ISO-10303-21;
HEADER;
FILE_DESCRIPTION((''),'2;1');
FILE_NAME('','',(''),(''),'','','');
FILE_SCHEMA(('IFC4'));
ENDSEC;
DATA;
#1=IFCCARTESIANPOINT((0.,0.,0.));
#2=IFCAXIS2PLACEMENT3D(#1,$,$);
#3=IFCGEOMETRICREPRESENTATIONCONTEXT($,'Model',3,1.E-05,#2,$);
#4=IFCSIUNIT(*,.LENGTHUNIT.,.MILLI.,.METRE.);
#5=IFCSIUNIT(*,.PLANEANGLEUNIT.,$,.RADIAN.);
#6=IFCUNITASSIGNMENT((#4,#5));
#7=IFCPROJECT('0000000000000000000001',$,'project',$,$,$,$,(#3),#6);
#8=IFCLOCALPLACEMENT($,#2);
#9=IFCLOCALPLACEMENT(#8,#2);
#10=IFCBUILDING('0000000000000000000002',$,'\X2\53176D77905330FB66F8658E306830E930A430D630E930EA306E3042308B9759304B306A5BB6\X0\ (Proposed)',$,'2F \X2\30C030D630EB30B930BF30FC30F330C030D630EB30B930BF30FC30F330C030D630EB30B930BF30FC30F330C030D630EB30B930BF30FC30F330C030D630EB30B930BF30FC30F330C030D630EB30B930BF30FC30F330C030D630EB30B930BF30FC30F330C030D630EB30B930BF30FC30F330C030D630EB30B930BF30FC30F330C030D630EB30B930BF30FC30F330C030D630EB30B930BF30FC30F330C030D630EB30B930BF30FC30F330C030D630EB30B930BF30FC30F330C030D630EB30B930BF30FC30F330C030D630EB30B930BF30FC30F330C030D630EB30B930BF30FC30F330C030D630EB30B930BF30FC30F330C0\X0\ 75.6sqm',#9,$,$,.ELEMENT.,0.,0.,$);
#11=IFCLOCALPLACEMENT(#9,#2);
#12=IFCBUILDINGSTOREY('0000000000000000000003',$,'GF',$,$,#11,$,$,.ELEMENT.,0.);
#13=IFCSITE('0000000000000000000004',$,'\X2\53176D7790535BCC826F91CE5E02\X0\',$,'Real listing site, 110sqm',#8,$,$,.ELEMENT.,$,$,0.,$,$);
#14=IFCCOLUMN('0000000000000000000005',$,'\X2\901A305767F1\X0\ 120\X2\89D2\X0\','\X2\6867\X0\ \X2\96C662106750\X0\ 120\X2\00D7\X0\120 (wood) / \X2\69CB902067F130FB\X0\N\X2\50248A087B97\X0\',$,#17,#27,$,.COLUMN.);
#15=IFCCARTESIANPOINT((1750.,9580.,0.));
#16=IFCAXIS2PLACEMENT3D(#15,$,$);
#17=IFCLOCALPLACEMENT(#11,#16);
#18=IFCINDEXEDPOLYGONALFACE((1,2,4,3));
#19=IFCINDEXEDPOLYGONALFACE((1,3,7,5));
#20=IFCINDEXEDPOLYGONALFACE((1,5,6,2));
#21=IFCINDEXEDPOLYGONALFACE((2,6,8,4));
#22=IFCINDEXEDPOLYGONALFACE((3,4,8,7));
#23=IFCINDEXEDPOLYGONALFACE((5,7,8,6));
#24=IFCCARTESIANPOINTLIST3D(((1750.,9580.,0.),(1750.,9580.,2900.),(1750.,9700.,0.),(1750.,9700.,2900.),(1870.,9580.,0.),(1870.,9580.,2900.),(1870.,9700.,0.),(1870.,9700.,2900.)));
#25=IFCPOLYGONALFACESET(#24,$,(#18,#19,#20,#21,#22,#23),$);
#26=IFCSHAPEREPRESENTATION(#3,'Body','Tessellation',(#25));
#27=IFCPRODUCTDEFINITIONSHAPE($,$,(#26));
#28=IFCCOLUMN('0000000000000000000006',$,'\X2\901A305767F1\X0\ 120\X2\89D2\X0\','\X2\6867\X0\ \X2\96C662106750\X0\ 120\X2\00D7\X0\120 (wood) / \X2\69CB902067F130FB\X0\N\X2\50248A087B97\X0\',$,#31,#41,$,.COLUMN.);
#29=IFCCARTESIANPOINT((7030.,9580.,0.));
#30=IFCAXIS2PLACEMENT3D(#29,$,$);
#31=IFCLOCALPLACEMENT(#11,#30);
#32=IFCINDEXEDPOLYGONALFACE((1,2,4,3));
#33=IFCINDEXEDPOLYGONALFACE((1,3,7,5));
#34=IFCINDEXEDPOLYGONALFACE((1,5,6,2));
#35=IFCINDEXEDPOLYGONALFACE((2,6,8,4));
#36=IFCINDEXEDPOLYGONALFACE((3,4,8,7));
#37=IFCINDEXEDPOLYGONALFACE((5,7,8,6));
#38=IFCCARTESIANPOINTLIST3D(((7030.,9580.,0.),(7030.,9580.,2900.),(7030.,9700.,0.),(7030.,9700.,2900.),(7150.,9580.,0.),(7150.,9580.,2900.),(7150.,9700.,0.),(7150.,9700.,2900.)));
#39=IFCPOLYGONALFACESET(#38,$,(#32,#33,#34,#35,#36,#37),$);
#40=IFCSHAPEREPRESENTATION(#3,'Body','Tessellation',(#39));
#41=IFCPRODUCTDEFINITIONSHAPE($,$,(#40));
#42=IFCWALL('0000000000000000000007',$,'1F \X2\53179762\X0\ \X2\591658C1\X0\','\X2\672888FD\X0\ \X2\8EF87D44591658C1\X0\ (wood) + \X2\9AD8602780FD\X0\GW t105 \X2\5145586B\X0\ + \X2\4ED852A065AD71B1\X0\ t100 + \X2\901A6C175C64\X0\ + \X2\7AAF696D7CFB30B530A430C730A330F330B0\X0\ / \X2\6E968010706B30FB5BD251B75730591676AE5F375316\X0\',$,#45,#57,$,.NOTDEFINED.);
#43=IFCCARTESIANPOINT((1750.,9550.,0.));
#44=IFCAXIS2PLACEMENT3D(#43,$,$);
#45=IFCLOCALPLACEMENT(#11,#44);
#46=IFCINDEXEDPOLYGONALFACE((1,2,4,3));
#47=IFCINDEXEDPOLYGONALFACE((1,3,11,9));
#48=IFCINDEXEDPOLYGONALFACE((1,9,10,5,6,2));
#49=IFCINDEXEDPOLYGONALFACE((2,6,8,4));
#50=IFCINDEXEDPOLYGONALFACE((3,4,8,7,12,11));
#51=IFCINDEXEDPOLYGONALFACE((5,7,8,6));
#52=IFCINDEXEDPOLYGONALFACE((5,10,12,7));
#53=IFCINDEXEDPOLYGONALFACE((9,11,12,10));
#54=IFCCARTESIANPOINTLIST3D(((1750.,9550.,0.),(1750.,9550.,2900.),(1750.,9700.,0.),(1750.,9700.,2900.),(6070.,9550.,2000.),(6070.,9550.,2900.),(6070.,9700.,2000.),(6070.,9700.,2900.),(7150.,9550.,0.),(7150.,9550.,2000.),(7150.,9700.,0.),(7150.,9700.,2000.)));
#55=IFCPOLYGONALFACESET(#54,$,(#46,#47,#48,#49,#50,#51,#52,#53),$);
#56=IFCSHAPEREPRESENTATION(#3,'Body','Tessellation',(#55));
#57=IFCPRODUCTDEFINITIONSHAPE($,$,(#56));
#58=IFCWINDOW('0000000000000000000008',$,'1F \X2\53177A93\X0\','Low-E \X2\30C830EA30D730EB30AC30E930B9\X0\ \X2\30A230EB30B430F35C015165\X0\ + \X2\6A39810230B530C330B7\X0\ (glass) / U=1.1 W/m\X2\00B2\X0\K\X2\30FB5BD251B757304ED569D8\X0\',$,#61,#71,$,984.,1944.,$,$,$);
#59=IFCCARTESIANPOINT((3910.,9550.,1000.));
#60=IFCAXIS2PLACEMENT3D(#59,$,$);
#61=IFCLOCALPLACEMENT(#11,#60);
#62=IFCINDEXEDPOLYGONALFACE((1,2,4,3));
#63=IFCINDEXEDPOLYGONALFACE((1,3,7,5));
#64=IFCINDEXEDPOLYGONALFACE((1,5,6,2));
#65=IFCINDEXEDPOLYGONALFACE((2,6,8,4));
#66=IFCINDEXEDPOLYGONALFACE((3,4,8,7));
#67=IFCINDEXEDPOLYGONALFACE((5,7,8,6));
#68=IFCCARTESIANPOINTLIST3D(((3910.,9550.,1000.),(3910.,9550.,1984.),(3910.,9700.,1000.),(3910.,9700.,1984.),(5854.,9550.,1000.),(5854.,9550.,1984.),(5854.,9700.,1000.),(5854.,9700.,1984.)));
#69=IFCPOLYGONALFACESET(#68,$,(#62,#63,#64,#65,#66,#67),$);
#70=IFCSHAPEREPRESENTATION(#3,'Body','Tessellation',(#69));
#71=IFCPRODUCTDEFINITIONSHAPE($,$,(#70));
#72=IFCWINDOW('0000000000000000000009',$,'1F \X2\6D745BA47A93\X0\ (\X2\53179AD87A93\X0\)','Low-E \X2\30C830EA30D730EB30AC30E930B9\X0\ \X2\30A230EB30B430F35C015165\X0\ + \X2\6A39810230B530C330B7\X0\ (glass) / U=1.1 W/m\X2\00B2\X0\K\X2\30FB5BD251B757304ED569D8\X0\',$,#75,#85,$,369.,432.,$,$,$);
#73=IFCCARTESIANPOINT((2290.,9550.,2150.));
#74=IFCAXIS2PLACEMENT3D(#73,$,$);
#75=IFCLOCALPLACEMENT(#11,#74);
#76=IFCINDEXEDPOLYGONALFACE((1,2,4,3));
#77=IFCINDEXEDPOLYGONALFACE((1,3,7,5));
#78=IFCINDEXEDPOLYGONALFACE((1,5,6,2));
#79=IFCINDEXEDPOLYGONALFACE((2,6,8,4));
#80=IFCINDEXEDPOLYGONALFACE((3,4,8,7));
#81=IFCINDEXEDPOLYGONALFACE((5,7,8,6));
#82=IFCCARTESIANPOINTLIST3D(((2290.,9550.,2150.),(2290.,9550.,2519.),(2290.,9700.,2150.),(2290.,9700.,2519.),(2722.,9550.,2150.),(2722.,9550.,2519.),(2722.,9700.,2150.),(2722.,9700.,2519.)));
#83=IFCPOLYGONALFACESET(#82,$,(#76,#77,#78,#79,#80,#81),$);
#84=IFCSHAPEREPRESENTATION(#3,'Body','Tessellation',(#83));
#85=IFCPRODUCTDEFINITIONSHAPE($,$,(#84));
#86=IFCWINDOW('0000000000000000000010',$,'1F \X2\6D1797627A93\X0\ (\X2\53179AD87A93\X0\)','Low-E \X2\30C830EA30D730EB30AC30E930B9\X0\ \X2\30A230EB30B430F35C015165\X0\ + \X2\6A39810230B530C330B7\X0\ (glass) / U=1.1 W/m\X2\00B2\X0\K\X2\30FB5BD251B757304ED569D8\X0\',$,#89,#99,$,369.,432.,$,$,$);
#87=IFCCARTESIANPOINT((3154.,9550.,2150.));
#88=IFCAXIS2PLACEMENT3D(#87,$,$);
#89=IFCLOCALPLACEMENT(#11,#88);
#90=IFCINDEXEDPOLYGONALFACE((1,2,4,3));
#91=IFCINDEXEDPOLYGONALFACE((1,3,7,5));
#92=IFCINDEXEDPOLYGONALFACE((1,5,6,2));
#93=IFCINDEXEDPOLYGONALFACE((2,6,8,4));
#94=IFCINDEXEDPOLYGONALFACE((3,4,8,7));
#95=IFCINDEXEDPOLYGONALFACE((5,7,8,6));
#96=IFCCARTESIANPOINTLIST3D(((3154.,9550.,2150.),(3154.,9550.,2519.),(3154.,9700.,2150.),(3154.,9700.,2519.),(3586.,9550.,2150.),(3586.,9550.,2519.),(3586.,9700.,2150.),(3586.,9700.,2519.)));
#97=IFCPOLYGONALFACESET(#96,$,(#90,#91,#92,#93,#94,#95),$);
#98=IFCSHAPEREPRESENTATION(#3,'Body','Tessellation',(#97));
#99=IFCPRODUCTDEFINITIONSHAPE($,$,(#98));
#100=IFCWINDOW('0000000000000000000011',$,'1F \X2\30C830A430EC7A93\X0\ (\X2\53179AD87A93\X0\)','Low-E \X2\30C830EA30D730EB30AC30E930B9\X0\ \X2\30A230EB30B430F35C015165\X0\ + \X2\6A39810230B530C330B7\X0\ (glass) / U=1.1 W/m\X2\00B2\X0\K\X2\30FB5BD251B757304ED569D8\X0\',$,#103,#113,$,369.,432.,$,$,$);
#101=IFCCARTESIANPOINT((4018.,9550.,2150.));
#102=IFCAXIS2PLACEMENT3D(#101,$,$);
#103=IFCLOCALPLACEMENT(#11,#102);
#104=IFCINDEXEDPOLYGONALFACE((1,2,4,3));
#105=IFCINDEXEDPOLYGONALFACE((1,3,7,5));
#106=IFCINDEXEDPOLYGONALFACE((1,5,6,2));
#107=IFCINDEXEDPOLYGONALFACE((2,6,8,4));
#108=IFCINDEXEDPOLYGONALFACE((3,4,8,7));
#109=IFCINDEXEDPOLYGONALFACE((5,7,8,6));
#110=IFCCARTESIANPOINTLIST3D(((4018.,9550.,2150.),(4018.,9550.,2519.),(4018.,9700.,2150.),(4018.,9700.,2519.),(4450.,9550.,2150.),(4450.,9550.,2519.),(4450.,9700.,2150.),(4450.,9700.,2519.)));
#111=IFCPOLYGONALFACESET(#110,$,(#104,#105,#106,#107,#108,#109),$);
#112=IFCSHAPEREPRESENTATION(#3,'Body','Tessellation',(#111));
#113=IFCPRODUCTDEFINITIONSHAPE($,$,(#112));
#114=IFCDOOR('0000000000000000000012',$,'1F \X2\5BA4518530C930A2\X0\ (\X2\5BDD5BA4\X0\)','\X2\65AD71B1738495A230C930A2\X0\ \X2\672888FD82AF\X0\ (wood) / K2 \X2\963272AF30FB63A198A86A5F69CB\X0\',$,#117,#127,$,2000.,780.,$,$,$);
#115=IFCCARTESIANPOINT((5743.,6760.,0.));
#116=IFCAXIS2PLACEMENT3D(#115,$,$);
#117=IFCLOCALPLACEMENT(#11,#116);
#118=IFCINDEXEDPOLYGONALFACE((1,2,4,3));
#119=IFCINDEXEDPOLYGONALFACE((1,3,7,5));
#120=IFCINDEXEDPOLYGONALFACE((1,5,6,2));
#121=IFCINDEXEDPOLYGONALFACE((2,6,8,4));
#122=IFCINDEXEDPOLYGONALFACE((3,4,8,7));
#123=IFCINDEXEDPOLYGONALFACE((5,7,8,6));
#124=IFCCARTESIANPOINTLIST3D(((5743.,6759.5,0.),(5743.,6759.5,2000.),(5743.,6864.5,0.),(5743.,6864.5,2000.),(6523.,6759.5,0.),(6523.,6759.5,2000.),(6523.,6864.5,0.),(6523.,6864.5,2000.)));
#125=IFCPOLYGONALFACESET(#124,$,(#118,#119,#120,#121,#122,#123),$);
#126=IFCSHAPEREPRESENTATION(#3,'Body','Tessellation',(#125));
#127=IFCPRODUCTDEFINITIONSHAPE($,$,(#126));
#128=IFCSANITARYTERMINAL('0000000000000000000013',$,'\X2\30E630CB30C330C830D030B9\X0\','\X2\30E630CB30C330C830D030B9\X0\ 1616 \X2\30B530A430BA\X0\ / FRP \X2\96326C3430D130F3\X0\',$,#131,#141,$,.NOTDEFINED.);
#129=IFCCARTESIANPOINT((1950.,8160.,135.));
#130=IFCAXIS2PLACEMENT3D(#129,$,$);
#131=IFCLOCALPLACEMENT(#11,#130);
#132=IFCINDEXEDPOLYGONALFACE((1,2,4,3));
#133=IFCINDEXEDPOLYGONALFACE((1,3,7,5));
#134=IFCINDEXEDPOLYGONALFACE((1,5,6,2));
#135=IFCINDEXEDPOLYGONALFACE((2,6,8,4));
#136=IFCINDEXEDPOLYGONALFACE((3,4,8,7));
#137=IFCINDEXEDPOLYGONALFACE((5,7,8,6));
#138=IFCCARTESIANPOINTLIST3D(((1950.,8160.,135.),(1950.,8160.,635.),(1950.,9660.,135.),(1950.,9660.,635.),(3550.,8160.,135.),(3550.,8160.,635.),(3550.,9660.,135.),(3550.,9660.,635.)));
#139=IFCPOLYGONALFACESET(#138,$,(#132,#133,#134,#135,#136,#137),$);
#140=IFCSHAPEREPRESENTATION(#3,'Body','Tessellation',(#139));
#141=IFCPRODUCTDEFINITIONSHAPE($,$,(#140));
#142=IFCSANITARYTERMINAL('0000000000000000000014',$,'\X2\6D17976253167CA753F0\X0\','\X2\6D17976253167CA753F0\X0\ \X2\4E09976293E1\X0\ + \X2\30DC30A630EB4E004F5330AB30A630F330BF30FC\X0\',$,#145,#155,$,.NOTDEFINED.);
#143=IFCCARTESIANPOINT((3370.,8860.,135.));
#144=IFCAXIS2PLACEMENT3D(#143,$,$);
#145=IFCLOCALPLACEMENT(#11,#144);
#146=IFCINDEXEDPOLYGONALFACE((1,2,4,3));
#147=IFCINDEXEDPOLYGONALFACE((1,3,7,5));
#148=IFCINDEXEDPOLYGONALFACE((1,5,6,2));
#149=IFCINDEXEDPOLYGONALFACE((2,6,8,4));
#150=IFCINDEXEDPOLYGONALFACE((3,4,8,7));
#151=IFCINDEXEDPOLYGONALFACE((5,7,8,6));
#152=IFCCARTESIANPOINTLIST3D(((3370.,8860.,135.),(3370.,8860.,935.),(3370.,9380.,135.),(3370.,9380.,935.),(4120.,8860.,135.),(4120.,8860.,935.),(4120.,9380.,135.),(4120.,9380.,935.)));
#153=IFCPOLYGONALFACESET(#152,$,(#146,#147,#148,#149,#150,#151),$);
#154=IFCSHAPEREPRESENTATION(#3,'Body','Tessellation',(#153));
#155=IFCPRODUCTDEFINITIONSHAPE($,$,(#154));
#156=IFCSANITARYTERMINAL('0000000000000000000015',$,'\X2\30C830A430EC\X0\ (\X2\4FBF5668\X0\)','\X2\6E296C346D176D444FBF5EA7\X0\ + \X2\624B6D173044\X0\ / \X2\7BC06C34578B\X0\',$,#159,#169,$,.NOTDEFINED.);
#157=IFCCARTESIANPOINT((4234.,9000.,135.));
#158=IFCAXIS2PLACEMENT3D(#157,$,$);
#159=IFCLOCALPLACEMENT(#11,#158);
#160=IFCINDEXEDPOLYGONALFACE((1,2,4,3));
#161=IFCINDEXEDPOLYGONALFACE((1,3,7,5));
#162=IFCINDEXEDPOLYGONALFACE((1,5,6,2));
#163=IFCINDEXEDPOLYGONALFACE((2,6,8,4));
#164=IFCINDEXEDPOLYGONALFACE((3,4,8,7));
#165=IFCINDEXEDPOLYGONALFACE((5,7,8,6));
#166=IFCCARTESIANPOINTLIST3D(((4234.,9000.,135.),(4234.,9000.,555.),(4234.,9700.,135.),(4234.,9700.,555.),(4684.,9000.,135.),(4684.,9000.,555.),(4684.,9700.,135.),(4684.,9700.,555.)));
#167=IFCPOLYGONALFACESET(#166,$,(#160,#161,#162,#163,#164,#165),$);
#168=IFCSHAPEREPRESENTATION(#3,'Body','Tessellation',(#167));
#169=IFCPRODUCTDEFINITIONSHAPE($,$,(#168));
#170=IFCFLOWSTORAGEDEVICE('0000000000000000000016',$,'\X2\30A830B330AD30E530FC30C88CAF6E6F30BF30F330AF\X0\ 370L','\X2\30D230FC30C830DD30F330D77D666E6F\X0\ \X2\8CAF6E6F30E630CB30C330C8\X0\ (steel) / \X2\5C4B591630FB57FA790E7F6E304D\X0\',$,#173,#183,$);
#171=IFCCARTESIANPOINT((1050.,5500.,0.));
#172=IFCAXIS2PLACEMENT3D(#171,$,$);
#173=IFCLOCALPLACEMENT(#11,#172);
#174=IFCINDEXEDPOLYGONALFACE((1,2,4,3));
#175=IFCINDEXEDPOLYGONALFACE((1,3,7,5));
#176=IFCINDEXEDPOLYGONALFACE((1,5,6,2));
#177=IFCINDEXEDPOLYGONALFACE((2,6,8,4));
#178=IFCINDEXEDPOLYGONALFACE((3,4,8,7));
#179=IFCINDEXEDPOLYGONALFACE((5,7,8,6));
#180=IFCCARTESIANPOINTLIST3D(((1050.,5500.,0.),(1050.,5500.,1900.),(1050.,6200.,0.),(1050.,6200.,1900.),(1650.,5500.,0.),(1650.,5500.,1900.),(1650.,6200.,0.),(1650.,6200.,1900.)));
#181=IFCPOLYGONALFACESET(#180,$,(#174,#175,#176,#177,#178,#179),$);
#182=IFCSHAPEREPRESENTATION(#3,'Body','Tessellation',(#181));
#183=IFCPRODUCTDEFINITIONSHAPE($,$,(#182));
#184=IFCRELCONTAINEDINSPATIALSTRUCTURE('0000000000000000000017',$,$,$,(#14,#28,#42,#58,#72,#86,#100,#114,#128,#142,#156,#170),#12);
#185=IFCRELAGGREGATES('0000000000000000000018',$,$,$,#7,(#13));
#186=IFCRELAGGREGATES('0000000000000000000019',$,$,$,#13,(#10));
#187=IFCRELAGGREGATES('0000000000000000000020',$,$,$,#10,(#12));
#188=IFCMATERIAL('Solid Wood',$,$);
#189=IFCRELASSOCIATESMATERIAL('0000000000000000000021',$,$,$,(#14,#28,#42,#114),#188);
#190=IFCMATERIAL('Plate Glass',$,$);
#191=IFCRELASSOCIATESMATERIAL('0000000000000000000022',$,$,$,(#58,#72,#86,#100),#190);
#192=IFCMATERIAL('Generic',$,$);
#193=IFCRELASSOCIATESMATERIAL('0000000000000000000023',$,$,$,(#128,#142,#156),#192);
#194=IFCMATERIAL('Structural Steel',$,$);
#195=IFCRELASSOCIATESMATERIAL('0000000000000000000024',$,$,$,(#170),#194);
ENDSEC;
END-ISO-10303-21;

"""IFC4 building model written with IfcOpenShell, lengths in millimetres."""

from ifc_helpers import new_model, si_unit, frame, frame_2d, origin, place, context, project, spatial, rectangle, extrude, material, element, fill, save


model = new_model("IFC4")

# Units and contexts
model_context = context("Model", 3, precision=1e-05, world=origin())
ifc_project = project(units=[si_unit("LENGTHUNIT", "METRE", prefix="MILLI"), si_unit("PLANEANGLEUNIT", "RADIAN")], contexts=[model_context])

# Site, building, storey
site_placement = place(None, origin())
site = spatial("IfcSite", under=ifc_project, at=site_placement, Name="北海道富良野市", ObjectType="Real listing site, 110sqm", CompositionType="ELEMENT", RefElevation=0.0)
building_placement = place(site_placement, origin())
building = spatial("IfcBuilding", under=site, at=building_placement, Name="北海道・書斎とライブラリのある静かな家 (Proposed)", ObjectType="2F ダブルスターンダブルスターンダブルスターンダブルスターンダブルスターンダブルスターンダブルスターンダブルスターンダブルスターンダブルスターンダブルスターンダブルスターンダブルスターンダブルスターンダブルスターンダブルスターンダブルスターンダ 75.6sqm", CompositionType="ELEMENT", ElevationOfRefHeight=0.0, ElevationOfTerrain=0.0)
storey_placement = place(building_placement, origin())
storey = spatial("IfcBuildingStorey", under=building, at=storey_placement, Name="GF", CompositionType="ELEMENT", Elevation=0.0)

# Columns
ifc_material_1 = material(Name="Solid Wood")
column_1_placement = place(storey_placement, frame((1750.0, 9580.0, 0.0)))
element("IfcColumn", 1, at=column_1_placement, inside=storey, material=ifc_material_1, Name="通し柱 120角", Description="桧 集成材 120×120 (wood) / 構造柱・N値計算", PredefinedType="COLUMN", context=model_context, shape_type="SweptSolid", body=[
    extrude(rectangle(XDim=120.0, YDim=120.0, at=frame_2d((60.0, 60.0))), frame((1750.0, 9580.0, 0.0)), (0.0, 0.0, 1.0), 2900.0),
])
column_2_placement = place(storey_placement, frame((7030.0, 9580.0, 0.0)))
element("IfcColumn", 2, at=column_2_placement, inside=storey, material=ifc_material_1, Name="通し柱 120角", Description="桧 集成材 120×120 (wood) / 構造柱・N値計算", PredefinedType="COLUMN", context=model_context, shape_type="SweptSolid", body=[
    extrude(rectangle(XDim=120.0, YDim=120.0, at=frame_2d((60.0, 60.0))), frame((7030.0, 9580.0, 0.0)), (0.0, 0.0, 1.0), 2900.0),
])

# Wall, openings, windows
wall_1_placement = place(storey_placement, frame((1750.0, 9550.0, 0.0)))
wall_1 = element("IfcWall", 3, at=wall_1_placement, inside=storey, material=ifc_material_1, Name="1F 北面 外壁", Description="木製 軸組外壁 (wood) + 高性能GW t105 充填 + 付加断熱 t100 + 通気層 + 窯業系サイディング / 準耐火・寒冷地外皮強化", PredefinedType="NOTDEFINED", context=model_context, shape_type="SweptSolid", body=[
    extrude(rectangle(XDim=5400.0, YDim=150.0, at=frame_2d((2700.0, 75.0))), frame((1750.0, 9550.0, 0.0)), (0.0, 0.0, 1.0), 2900.0),
])
opening_1_placement = place(storey_placement, frame((3910.0, 9550.0, 1000.0)))
opening_1 = element("IfcOpeningElement", 4, at=opening_1_placement, cuts=wall_1, PredefinedType="NOTDEFINED", context=model_context, shape_type="SweptSolid", body=[
    extrude(rectangle(XDim=1944.0, YDim=150.0, at=frame_2d((972.0, 75.0))), frame((3910.0, 9550.0, 1000.0)), (0.0, 0.0, 1.0), 984.0),
])
opening_2_placement = place(storey_placement, frame((2290.0, 9550.0, 2150.0)))
opening_2 = element("IfcOpeningElement", 5, at=opening_2_placement, cuts=wall_1, PredefinedType="NOTDEFINED", context=model_context, shape_type="SweptSolid", body=[
    extrude(rectangle(XDim=432.0, YDim=150.0, at=frame_2d((216.0, 75.0))), frame((2290.0, 9550.0, 2150.0)), (0.0, 0.0, 1.0), 369.0),
])
opening_3_placement = place(storey_placement, frame((3154.0, 9550.0, 2150.0)))
opening_3 = element("IfcOpeningElement", 6, at=opening_3_placement, cuts=wall_1, PredefinedType="NOTDEFINED", context=model_context, shape_type="SweptSolid", body=[
    extrude(rectangle(XDim=432.0, YDim=150.0, at=frame_2d((216.0, 75.0))), frame((3154.0, 9550.0, 2150.0)), (0.0, 0.0, 1.0), 369.0),
])
opening_4_placement = place(storey_placement, frame((4018.0, 9550.0, 2150.0)))
opening_4 = element("IfcOpeningElement", 7, at=opening_4_placement, cuts=wall_1, PredefinedType="NOTDEFINED", context=model_context, shape_type="SweptSolid", body=[
    extrude(rectangle(XDim=432.0, YDim=150.0, at=frame_2d((216.0, 75.0))), frame((4018.0, 9550.0, 2150.0)), (0.0, 0.0, 1.0), 369.0),
])
ifc_material_2 = material(Name="Plate Glass")
window_1_placement = place(storey_placement, frame((3910.0, 9550.0, 1000.0)))
window_1 = element("IfcWindow", 8, at=window_1_placement, inside=storey, material=ifc_material_2, Name="1F 北窓", Description="Low-E トリプルガラス アルゴン封入 + 樹脂サッシ (glass) / U=1.1 W/m²K・寒冷地仕様", OverallHeight=984.0, OverallWidth=1944.0, context=model_context, shape_type="SweptSolid", body=[
    extrude(rectangle(XDim=1944.0, YDim=150.0, at=frame_2d((972.0, 75.0))), frame((3910.0, 9550.0, 1000.0)), (0.0, 0.0, 1.0), 984.0),
])
fill(opening_1, window_1)
window_2_placement = place(storey_placement, frame((2290.0, 9550.0, 2150.0)))
window_2 = element("IfcWindow", 9, at=window_2_placement, inside=storey, material=ifc_material_2, Name="1F 浴室窓 (北高窓)", Description="Low-E トリプルガラス アルゴン封入 + 樹脂サッシ (glass) / U=1.1 W/m²K・寒冷地仕様", OverallHeight=369.0, OverallWidth=432.0, context=model_context, shape_type="SweptSolid", body=[
    extrude(rectangle(XDim=432.0, YDim=150.0, at=frame_2d((216.0, 75.0))), frame((2290.0, 9550.0, 2150.0)), (0.0, 0.0, 1.0), 369.0),
])
fill(opening_2, window_2)
window_3_placement = place(storey_placement, frame((3154.0, 9550.0, 2150.0)))
window_3 = element("IfcWindow", 10, at=window_3_placement, inside=storey, material=ifc_material_2, Name="1F 洗面窓 (北高窓)", Description="Low-E トリプルガラス アルゴン封入 + 樹脂サッシ (glass) / U=1.1 W/m²K・寒冷地仕様", OverallHeight=369.0, OverallWidth=432.0, context=model_context, shape_type="SweptSolid", body=[
    extrude(rectangle(XDim=432.0, YDim=150.0, at=frame_2d((216.0, 75.0))), frame((3154.0, 9550.0, 2150.0)), (0.0, 0.0, 1.0), 369.0),
])
fill(opening_3, window_3)
window_4_placement = place(storey_placement, frame((4018.0, 9550.0, 2150.0)))
window_4 = element("IfcWindow", 11, at=window_4_placement, inside=storey, material=ifc_material_2, Name="1F トイレ窓 (北高窓)", Description="Low-E トリプルガラス アルゴン封入 + 樹脂サッシ (glass) / U=1.1 W/m²K・寒冷地仕様", OverallHeight=369.0, OverallWidth=432.0, context=model_context, shape_type="SweptSolid", body=[
    extrude(rectangle(XDim=432.0, YDim=150.0, at=frame_2d((216.0, 75.0))), frame((4018.0, 9550.0, 2150.0)), (0.0, 0.0, 1.0), 369.0),
])
fill(opening_4, window_4)

# Door
door_1_placement = place(storey_placement, frame((5743.0, 6760.0, 0.0)))
element("IfcDoor", 12, at=door_1_placement, inside=storey, material=ifc_material_1, Name="1F 室内ドア (寝室)", Description="断熱玄関ドア 木製芯 (wood) / K2 防犯・採風機構", OverallHeight=2000.0, OverallWidth=780.0, context=model_context, shape_type="SweptSolid", body=[
    extrude(rectangle(XDim=780.0, YDim=105.0, at=frame_2d((390.0, 52.0))), frame((5743.0, 6760.0, 0.0)), (0.0, 0.0, 1.0), 2000.0),
])

# Sanitary terminals
ifc_material_3 = material(Name="Generic")
sanitary_terminal_1_placement = place(storey_placement, frame((1950.0, 8160.0, 135.0)))
element("IfcSanitaryTerminal", 13, at=sanitary_terminal_1_placement, inside=storey, material=ifc_material_3, Name="ユニットバス", Description="ユニットバス 1616 サイズ / FRP 防水パン", PredefinedType="NOTDEFINED", context=model_context, shape_type="SweptSolid", body=[
    extrude(rectangle(XDim=1600.0, YDim=1500.0, at=frame_2d((800.0, 750.0))), frame((1950.0, 8160.0, 135.0)), (0.0, 0.0, 1.0), 500.0),
])
sanitary_terminal_2_placement = place(storey_placement, frame((3370.0, 8860.0, 135.0)))
element("IfcSanitaryTerminal", 14, at=sanitary_terminal_2_placement, inside=storey, material=ifc_material_3, Name="洗面化粧台", Description="洗面化粧台 三面鏡 + ボウル一体カウンター", PredefinedType="NOTDEFINED", context=model_context, shape_type="SweptSolid", body=[
    extrude(rectangle(XDim=750.0, YDim=520.0, at=frame_2d((375.0, 260.0))), frame((3370.0, 8860.0, 135.0)), (0.0, 0.0, 1.0), 800.0),
])
sanitary_terminal_3_placement = place(storey_placement, frame((4234.0, 9000.0, 135.0)))
element("IfcSanitaryTerminal", 15, at=sanitary_terminal_3_placement, inside=storey, material=ifc_material_3, Name="トイレ (便器)", Description="温水洗浄便座 + 手洗い / 節水型", PredefinedType="NOTDEFINED", context=model_context, shape_type="SweptSolid", body=[
    extrude(rectangle(XDim=450.0, YDim=700.0, at=frame_2d((225.0, 350.0))), frame((4234.0, 9000.0, 135.0)), (0.0, 0.0, 1.0), 420.0),
])

# Flow storage device
ifc_material_4 = material(Name="Structural Steel")
flow_storage_device_placement = place(storey_placement, frame((1050.0, 5500.0, 0.0)))
element("IfcFlowStorageDevice", 16, at=flow_storage_device_placement, inside=storey, material=ifc_material_4, Name="エコキュート貯湯タンク 370L", Description="ヒートポンプ給湯 貯湯ユニット (steel) / 屋外・基礎置き", context=model_context, shape_type="SweptSolid", body=[
    extrude(rectangle(XDim=600.0, YDim=700.0, at=frame_2d((300.0, 350.0))), frame((1050.0, 5500.0, 0.0)), (0.0, 0.0, 1.0), 1900.0),
])

save(model, "model.ifc")
